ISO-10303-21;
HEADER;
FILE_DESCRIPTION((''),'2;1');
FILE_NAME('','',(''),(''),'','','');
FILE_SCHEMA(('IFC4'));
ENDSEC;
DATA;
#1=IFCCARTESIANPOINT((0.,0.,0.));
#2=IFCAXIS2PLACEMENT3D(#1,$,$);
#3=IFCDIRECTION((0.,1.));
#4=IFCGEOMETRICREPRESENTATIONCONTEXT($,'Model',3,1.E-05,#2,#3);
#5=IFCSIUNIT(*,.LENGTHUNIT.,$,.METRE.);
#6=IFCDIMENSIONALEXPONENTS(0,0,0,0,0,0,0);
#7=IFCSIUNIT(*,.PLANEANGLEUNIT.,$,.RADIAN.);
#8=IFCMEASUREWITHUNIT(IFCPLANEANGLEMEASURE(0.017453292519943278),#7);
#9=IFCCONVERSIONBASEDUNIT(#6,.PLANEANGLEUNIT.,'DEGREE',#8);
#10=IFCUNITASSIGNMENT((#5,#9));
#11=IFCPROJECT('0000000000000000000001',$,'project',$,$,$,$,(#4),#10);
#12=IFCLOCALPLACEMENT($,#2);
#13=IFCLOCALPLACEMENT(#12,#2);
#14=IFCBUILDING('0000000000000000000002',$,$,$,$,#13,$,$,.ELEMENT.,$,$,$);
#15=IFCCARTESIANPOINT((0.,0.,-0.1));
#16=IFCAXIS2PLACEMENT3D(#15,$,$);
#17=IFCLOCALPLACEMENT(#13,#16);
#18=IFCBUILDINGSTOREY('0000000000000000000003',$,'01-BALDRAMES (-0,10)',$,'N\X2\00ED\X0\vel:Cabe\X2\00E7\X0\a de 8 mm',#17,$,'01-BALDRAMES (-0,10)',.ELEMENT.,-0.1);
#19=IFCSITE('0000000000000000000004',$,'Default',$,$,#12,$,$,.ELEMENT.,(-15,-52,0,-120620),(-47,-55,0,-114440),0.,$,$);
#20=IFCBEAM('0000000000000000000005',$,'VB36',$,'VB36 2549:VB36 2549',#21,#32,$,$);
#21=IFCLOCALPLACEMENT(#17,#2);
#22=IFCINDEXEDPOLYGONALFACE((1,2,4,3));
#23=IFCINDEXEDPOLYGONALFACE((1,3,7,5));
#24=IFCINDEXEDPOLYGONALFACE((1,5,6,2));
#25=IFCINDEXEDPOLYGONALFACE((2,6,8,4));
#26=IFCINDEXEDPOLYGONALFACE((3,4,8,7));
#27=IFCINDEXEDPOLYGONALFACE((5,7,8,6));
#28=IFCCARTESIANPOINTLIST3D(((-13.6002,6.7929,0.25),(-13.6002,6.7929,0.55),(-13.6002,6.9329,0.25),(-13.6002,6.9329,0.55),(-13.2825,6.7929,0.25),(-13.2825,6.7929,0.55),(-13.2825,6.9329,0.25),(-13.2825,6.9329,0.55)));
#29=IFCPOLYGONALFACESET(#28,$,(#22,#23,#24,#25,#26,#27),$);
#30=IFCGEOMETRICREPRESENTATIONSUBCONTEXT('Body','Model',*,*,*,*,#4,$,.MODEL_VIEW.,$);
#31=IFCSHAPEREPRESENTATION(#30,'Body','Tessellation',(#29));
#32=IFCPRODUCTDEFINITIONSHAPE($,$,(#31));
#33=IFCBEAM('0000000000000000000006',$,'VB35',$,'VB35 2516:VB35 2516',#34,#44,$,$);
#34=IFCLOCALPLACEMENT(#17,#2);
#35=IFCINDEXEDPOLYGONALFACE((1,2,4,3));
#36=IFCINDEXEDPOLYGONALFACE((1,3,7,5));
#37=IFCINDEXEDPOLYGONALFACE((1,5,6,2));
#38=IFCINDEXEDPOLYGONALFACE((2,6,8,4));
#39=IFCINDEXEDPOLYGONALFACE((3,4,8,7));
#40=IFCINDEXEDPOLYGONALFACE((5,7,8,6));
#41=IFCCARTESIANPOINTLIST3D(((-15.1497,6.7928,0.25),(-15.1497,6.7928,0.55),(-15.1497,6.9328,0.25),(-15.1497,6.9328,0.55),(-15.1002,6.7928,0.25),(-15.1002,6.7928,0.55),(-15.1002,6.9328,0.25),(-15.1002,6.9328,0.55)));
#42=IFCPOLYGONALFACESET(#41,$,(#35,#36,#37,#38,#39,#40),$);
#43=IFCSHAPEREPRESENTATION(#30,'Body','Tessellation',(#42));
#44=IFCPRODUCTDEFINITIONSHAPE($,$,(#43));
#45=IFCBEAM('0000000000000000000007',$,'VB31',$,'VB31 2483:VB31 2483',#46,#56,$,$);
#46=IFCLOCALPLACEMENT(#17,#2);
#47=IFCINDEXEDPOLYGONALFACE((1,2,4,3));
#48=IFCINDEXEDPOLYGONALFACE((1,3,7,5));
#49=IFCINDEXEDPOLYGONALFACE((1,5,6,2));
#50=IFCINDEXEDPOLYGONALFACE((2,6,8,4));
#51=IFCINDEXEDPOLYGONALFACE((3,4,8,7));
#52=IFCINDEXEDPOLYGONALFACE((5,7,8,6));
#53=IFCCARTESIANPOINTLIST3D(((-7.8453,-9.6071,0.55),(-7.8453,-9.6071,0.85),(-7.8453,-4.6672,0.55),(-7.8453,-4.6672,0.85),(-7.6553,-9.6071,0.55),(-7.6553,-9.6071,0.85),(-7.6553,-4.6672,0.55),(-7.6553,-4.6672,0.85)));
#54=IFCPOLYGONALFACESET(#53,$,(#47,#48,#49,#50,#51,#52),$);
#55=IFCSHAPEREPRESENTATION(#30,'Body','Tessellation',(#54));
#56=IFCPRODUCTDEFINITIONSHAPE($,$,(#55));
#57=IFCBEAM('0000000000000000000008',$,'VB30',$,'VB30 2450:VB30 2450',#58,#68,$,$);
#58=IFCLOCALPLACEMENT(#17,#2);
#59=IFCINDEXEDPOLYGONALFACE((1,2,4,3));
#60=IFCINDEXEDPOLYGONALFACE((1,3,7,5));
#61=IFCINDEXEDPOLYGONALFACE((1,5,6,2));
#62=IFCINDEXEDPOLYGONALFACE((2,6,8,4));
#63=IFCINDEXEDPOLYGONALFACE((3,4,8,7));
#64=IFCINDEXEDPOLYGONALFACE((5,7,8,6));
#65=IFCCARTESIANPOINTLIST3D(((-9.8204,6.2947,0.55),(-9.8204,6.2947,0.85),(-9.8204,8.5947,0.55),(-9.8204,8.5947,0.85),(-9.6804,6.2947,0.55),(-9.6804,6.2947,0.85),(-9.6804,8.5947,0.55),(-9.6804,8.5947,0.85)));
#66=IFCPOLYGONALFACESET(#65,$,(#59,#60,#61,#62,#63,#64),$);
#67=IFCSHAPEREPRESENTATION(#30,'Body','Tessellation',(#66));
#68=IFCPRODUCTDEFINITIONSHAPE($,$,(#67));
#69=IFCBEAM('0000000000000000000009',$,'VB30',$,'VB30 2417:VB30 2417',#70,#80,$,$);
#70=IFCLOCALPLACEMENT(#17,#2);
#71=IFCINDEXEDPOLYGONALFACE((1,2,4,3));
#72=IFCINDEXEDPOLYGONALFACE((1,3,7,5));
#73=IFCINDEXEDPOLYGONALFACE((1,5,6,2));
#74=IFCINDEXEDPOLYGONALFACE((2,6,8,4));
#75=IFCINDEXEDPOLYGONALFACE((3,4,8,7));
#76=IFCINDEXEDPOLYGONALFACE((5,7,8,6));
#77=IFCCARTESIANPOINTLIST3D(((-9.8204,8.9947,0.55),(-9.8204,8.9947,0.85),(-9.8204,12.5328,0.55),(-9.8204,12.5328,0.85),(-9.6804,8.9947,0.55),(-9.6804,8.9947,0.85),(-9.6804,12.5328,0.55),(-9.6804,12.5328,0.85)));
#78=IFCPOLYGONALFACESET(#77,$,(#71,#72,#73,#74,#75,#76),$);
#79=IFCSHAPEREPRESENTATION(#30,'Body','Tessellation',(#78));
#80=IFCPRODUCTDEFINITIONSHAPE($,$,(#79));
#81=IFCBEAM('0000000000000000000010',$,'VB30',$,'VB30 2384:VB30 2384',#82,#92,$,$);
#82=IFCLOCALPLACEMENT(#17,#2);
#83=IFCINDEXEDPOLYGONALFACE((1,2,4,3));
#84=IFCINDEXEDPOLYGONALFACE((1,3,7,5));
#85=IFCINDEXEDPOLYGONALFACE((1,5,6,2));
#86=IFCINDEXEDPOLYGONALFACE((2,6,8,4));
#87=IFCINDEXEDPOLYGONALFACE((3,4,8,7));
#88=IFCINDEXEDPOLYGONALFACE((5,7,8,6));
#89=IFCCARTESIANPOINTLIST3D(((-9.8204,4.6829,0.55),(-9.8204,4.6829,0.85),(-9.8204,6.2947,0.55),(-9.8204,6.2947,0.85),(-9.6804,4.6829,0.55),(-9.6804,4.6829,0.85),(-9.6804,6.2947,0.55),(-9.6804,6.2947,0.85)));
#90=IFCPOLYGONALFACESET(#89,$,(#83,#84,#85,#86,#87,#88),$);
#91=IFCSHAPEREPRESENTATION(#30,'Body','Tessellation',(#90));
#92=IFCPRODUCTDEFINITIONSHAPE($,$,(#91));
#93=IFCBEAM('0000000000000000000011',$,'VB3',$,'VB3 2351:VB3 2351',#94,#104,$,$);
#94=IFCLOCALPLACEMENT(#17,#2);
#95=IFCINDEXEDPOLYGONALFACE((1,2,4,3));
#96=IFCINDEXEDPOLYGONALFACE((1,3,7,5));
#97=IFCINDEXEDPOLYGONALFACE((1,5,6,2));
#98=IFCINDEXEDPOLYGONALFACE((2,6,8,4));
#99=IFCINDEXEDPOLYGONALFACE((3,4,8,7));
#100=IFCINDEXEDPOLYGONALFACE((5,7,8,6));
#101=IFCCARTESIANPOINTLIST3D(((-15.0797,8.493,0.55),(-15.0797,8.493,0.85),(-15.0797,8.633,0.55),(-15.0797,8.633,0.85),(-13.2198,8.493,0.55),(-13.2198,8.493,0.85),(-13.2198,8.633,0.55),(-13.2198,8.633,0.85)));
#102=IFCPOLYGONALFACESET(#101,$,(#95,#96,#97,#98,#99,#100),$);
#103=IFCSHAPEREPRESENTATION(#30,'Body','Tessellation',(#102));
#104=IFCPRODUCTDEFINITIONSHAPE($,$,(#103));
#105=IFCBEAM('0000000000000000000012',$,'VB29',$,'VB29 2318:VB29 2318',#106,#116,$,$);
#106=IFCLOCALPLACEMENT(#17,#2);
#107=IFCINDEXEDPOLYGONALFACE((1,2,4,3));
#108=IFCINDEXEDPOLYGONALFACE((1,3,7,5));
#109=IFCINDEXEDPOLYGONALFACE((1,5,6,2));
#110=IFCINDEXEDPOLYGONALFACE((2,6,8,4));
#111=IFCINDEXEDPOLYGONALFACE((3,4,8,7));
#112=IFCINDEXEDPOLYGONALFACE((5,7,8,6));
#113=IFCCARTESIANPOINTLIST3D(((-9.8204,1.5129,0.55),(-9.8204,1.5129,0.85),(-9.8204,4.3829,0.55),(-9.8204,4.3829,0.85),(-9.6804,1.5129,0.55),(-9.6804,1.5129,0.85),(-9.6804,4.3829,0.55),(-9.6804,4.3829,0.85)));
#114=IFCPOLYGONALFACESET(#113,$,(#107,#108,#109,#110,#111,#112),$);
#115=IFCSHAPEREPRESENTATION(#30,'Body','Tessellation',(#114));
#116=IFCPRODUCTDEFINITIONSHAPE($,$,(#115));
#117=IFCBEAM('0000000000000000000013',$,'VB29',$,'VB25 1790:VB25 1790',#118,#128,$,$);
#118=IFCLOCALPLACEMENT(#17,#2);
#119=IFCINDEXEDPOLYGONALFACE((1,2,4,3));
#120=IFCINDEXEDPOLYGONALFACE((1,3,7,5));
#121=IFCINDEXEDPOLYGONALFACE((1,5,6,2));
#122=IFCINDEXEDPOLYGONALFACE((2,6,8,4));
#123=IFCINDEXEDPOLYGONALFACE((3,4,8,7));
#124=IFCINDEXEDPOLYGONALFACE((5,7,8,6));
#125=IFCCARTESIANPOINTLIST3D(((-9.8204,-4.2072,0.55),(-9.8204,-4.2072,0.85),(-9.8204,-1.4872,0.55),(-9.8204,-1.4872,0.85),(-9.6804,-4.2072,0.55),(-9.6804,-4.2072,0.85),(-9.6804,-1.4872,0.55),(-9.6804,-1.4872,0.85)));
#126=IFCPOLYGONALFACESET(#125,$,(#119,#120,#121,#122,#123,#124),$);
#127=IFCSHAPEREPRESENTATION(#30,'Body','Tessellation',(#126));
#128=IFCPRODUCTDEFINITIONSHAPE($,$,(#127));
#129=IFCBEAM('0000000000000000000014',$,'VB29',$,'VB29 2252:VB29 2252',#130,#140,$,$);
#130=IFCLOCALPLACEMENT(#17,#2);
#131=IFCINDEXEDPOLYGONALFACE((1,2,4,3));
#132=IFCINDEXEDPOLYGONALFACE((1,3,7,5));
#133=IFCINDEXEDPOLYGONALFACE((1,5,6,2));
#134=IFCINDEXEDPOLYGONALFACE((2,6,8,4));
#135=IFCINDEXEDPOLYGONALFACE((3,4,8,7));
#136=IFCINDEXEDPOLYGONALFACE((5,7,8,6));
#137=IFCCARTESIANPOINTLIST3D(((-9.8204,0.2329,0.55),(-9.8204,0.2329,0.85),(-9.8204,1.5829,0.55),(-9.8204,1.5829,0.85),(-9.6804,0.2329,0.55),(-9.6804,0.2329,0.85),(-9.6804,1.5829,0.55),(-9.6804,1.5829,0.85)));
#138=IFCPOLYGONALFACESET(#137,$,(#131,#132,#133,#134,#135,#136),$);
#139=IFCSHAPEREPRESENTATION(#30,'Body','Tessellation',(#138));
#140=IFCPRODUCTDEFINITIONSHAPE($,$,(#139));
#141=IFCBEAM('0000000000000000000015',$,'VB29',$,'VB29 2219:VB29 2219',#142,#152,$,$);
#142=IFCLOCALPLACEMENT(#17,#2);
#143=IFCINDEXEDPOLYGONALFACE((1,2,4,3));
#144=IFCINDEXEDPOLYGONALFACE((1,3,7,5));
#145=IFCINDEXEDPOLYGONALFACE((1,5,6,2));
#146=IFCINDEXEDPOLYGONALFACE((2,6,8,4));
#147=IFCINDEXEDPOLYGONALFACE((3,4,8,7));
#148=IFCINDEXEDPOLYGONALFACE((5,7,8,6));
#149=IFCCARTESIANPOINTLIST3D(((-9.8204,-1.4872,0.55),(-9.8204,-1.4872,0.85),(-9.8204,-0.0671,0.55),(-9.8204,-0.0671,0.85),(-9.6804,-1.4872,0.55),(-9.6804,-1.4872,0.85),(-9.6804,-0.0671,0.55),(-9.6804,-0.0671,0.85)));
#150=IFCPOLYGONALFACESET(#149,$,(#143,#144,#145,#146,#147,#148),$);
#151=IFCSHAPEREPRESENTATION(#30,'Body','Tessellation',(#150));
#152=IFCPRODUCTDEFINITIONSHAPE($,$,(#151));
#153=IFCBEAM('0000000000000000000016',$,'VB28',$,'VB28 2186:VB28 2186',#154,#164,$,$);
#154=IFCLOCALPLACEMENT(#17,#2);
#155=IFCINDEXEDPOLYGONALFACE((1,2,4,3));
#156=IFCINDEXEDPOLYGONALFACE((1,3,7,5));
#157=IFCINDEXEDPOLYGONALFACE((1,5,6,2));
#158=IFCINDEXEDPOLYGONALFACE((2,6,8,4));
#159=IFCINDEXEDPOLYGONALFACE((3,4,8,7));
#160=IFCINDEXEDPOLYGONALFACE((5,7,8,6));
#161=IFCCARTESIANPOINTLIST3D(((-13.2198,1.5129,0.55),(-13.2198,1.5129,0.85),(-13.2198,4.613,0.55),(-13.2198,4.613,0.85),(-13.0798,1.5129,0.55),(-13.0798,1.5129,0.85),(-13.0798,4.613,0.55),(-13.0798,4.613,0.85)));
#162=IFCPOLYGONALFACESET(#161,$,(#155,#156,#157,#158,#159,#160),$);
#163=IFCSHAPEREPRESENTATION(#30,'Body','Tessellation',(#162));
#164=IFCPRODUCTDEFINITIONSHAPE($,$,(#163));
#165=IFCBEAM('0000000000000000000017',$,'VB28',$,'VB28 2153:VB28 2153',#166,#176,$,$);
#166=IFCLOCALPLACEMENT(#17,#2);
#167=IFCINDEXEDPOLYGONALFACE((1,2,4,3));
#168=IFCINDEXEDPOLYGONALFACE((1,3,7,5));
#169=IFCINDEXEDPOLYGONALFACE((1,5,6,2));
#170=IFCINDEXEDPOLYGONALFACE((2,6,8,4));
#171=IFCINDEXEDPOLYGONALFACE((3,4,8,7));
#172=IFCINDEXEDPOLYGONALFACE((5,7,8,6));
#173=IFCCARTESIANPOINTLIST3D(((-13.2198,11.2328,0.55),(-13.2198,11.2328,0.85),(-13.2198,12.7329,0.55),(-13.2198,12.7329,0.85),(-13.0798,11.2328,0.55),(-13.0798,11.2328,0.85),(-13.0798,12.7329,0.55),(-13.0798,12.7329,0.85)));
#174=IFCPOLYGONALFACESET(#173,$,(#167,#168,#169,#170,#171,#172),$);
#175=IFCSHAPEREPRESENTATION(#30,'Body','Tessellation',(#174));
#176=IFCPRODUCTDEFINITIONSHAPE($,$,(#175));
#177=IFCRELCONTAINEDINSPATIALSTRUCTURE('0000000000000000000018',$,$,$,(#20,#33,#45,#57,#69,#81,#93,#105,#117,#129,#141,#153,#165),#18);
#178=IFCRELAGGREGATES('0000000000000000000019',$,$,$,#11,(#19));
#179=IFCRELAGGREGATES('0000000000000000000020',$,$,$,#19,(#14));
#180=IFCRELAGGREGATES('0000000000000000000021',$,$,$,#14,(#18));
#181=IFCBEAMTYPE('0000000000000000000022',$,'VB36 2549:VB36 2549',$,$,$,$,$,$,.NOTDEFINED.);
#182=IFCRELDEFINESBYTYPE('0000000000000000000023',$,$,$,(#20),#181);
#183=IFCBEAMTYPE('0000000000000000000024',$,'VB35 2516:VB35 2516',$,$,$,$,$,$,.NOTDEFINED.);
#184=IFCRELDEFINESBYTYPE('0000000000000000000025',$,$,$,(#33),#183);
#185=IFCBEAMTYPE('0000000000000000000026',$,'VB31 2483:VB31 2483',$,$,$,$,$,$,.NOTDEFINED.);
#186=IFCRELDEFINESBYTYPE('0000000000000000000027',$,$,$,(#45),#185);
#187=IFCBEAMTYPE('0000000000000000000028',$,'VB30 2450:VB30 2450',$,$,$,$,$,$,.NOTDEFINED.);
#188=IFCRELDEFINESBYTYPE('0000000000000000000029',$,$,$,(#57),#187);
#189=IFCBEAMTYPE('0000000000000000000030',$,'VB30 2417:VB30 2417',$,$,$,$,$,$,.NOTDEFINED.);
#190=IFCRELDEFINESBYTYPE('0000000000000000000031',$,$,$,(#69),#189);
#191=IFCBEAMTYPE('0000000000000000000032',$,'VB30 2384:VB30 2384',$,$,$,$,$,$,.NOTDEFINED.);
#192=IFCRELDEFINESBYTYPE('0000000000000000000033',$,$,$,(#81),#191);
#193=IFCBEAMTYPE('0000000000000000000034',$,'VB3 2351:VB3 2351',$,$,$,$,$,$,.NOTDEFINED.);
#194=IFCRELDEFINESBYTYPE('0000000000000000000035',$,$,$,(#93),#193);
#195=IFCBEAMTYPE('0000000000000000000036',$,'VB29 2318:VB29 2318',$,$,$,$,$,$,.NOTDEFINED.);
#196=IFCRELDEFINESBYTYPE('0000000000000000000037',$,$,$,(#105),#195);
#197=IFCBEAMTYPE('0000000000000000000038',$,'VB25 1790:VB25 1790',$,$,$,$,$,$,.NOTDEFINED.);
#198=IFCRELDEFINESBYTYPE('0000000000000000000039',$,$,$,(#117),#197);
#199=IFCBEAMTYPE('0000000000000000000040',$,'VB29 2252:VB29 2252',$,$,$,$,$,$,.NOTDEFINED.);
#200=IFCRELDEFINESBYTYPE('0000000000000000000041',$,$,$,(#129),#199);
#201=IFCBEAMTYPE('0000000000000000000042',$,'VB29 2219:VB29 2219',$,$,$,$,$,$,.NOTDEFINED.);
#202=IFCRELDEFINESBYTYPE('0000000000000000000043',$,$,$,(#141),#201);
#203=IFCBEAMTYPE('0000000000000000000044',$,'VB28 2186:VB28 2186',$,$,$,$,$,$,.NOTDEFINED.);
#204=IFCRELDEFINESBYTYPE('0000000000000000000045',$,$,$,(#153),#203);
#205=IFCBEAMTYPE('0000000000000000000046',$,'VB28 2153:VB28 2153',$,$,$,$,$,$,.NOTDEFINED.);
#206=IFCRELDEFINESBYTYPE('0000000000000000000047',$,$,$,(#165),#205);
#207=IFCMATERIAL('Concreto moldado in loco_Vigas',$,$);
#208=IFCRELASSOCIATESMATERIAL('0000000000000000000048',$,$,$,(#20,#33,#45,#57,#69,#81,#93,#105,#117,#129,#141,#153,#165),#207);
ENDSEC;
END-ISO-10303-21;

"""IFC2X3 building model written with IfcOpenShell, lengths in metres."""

from ifc_helpers import new_model, entity, si_unit, converted_unit, direction, frame, frame_2d, origin, place, context, subcontext, project, spatial, rectangle, extrude, material, type_object, element, save


model = new_model("IFC2X3")

# Units and contexts
model_context = context("Model", 3, precision=1e-05, world=origin(), true_north=direction((0.0, 1.0)))
body_context = subcontext(model_context, "Body", "Model", "MODEL_VIEW")
ifc_project = project(units=[si_unit("LENGTHUNIT", "METRE"), converted_unit("PLANEANGLEUNIT", "DEGREE", entity("IfcPlaneAngleMeasure", 0.017453292519943278), si_unit("PLANEANGLEUNIT", "RADIAN"), dimensions=[0, 0, 0, 0, 0, 0, 0])], contexts=[model_context])

# Site, building, storey
site_placement = place(None, origin())
site = spatial("IfcSite", under=ifc_project, at=site_placement, Name="Default", CompositionType="ELEMENT", RefLatitude=(-15, -52, 0, -120620), RefLongitude=(-47, -55, 0, -114440), RefElevation=0.0)
building_placement = place(site_placement, origin())
building = spatial("IfcBuilding", under=site, at=building_placement, CompositionType="ELEMENT")
storey_placement = place(building_placement, frame((0.0, 0.0, -0.1)))
storey = spatial("IfcBuildingStorey", under=building, at=storey_placement, Name="01-BALDRAMES (-0,10)", ObjectType="Nível:Cabeça de 8 mm", LongName="01-BALDRAMES (-0,10)", CompositionType="ELEMENT", Elevation=-0.1)

# Beams
ifc_material = material(Name="Concreto moldado in loco_Vigas")
beam_type_1 = type_object("IfcBeamType", Name="VB36 2549:VB36 2549", PredefinedType="NOTDEFINED")
beam_1_placement = place(storey_placement, origin())
element("IfcBeam", 1, at=beam_1_placement, inside=storey, type_object=beam_type_1, material=ifc_material, Name="VB36", ObjectType="VB36 2549:VB36 2549", context=body_context, shape_type="SweptSolid", body=[
    extrude(rectangle(XDim=0.3, YDim=0.14, at=frame_2d((0.0, 0.0), x_axis=(1.0, 0.0))), frame((-13.6002, 6.8629, 0.4), z_axis=(1.0, 0.0, 0.0), x_axis=(0.0, 0.0, -1.0)), (0.0, 0.0, 1.0), 0.3178),
])
beam_type_2 = type_object("IfcBeamType", Name="VB35 2516:VB35 2516", PredefinedType="NOTDEFINED")
beam_2_placement = place(storey_placement, origin())
element("IfcBeam", 2, at=beam_2_placement, inside=storey, type_object=beam_type_2, material=ifc_material, Name="VB35", ObjectType="VB35 2516:VB35 2516", context=body_context, shape_type="SweptSolid", body=[
    extrude(rectangle(XDim=0.3, YDim=0.14, at=frame_2d((0.0, 0.0), x_axis=(1.0, 0.0))), frame((-15.1497, 6.8628, 0.4), z_axis=(1.0, 0.0, 0.0), x_axis=(0.0, 0.0, -1.0)), (0.0, 0.0, 1.0), 0.0495),
])
beam_type_3 = type_object("IfcBeamType", Name="VB31 2483:VB31 2483", PredefinedType="NOTDEFINED")
beam_3_placement = place(storey_placement, origin())
element("IfcBeam", 3, at=beam_3_placement, inside=storey, type_object=beam_type_3, material=ifc_material, Name="VB31", ObjectType="VB31 2483:VB31 2483", context=body_context, shape_type="SweptSolid", body=[
    extrude(rectangle(XDim=0.3, YDim=4.9399, at=frame_2d((0.0, 0.0), x_axis=(0.0, 1.0))), frame((-7.8453, -7.1371, 0.7), z_axis=(1.0, 0.0, 0.0), x_axis=(0.0, -1.0, 0.0)), (0.0, 0.0, 1.0), 0.19),
])
beam_type_4 = type_object("IfcBeamType", Name="VB30 2450:VB30 2450", PredefinedType="NOTDEFINED")
beam_4_placement = place(storey_placement, origin())
element("IfcBeam", 4, at=beam_4_placement, inside=storey, type_object=beam_type_4, material=ifc_material, Name="VB30", ObjectType="VB30 2450:VB30 2450", context=body_context, shape_type="SweptSolid", body=[
    extrude(rectangle(XDim=0.3, YDim=2.3, at=frame_2d((0.0, 0.0), x_axis=(0.0, 1.0))), frame((-9.8204, 7.4447, 0.7), z_axis=(1.0, 0.0, 0.0), x_axis=(0.0, -1.0, 0.0)), (0.0, 0.0, 1.0), 0.14),
])
beam_type_5 = type_object("IfcBeamType", Name="VB30 2417:VB30 2417", PredefinedType="NOTDEFINED")
beam_5_placement = place(storey_placement, origin())
element("IfcBeam", 5, at=beam_5_placement, inside=storey, type_object=beam_type_5, material=ifc_material, Name="VB30", ObjectType="VB30 2417:VB30 2417", context=body_context, shape_type="SweptSolid", body=[
    extrude(rectangle(XDim=0.3, YDim=3.5381, at=frame_2d((0.0, 0.0), x_axis=(0.0, 1.0))), frame((-9.8204, 10.7638, 0.7), z_axis=(1.0, 0.0, 0.0), x_axis=(0.0, -1.0, 0.0)), (0.0, 0.0, 1.0), 0.14),
])
beam_type_6 = type_object("IfcBeamType", Name="VB30 2384:VB30 2384", PredefinedType="NOTDEFINED")
beam_6_placement = place(storey_placement, origin())
element("IfcBeam", 6, at=beam_6_placement, inside=storey, type_object=beam_type_6, material=ifc_material, Name="VB30", ObjectType="VB30 2384:VB30 2384", context=body_context, shape_type="SweptSolid", body=[
    extrude(rectangle(XDim=0.3, YDim=1.6118, at=frame_2d((0.0, 0.0), x_axis=(0.0, 1.0))), frame((-9.8204, 5.4888, 0.7), z_axis=(1.0, 0.0, 0.0), x_axis=(0.0, -1.0, 0.0)), (0.0, 0.0, 1.0), 0.14),
])
beam_type_7 = type_object("IfcBeamType", Name="VB3 2351:VB3 2351", PredefinedType="NOTDEFINED")
beam_7_placement = place(storey_placement, origin())
element("IfcBeam", 7, at=beam_7_placement, inside=storey, type_object=beam_type_7, material=ifc_material, Name="VB3", ObjectType="VB3 2351:VB3 2351", context=body_context, shape_type="SweptSolid", body=[
    extrude(rectangle(XDim=0.3, YDim=0.14, at=frame_2d((0.0, 0.0), x_axis=(1.0, 0.0))), frame((-15.0797, 8.563, 0.7), z_axis=(1.0, 0.0, 0.0), x_axis=(0.0, 0.0, -1.0)), (0.0, 0.0, 1.0), 1.8599),
])
beam_type_8 = type_object("IfcBeamType", Name="VB29 2318:VB29 2318", PredefinedType="NOTDEFINED")
beam_8_placement = place(storey_placement, origin())
element("IfcBeam", 8, at=beam_8_placement, inside=storey, type_object=beam_type_8, material=ifc_material, Name="VB29", ObjectType="VB29 2318:VB29 2318", context=body_context, shape_type="SweptSolid", body=[
    extrude(rectangle(XDim=0.3, YDim=2.87, at=frame_2d((0.0, 0.0), x_axis=(0.0, 1.0))), frame((-9.8204, 2.9479, 0.7), z_axis=(1.0, 0.0, 0.0), x_axis=(0.0, -1.0, 0.0)), (0.0, 0.0, 1.0), 0.14),
])
beam_type_9 = type_object("IfcBeamType", Name="VB25 1790:VB25 1790", PredefinedType="NOTDEFINED")
beam_9_placement = place(storey_placement, origin())
element("IfcBeam", 9, at=beam_9_placement, inside=storey, type_object=beam_type_9, material=ifc_material, Name="VB29", ObjectType="VB25 1790:VB25 1790", context=body_context, shape_type="SweptSolid", body=[
    extrude(rectangle(XDim=0.3, YDim=2.72, at=frame_2d((0.0, 0.0), x_axis=(0.0, 1.0))), frame((-9.8204, -2.8472, 0.7), z_axis=(1.0, 0.0, 0.0), x_axis=(0.0, -1.0, 0.0)), (0.0, 0.0, 1.0), 0.14),
])
beam_type_10 = type_object("IfcBeamType", Name="VB29 2252:VB29 2252", PredefinedType="NOTDEFINED")
beam_10_placement = place(storey_placement, origin())
element("IfcBeam", 10, at=beam_10_placement, inside=storey, type_object=beam_type_10, material=ifc_material, Name="VB29", ObjectType="VB29 2252:VB29 2252", context=body_context, shape_type="SweptSolid", body=[
    extrude(rectangle(XDim=0.3, YDim=1.35, at=frame_2d((0.0, 0.0), x_axis=(0.0, 1.0))), frame((-9.8204, 0.9079, 0.7), z_axis=(1.0, 0.0, 0.0), x_axis=(0.0, -1.0, 0.0)), (0.0, 0.0, 1.0), 0.14),
])
beam_type_11 = type_object("IfcBeamType", Name="VB29 2219:VB29 2219", PredefinedType="NOTDEFINED")
beam_11_placement = place(storey_placement, origin())
element("IfcBeam", 11, at=beam_11_placement, inside=storey, type_object=beam_type_11, material=ifc_material, Name="VB29", ObjectType="VB29 2219:VB29 2219", context=body_context, shape_type="SweptSolid", body=[
    extrude(rectangle(XDim=0.3, YDim=1.4201, at=frame_2d((0.0, 0.0), x_axis=(0.0, 1.0))), frame((-9.8204, -0.7771, 0.7), z_axis=(1.0, 0.0, 0.0), x_axis=(0.0, -1.0, 0.0)), (0.0, 0.0, 1.0), 0.14),
])
beam_type_12 = type_object("IfcBeamType", Name="VB28 2186:VB28 2186", PredefinedType="NOTDEFINED")
beam_12_placement = place(storey_placement, origin())
element("IfcBeam", 12, at=beam_12_placement, inside=storey, type_object=beam_type_12, material=ifc_material, Name="VB28", ObjectType="VB28 2186:VB28 2186", context=body_context, shape_type="SweptSolid", body=[
    extrude(rectangle(XDim=0.3, YDim=3.1001, at=frame_2d((0.0, 0.0), x_axis=(0.0, 1.0))), frame((-13.2198, 3.063, 0.7), z_axis=(1.0, 0.0, 0.0), x_axis=(0.0, -1.0, 0.0)), (0.0, 0.0, 1.0), 0.14),
])
beam_type_13 = type_object("IfcBeamType", Name="VB28 2153:VB28 2153", PredefinedType="NOTDEFINED")
beam_13_placement = place(storey_placement, origin())
element("IfcBeam", 13, at=beam_13_placement, inside=storey, type_object=beam_type_13, material=ifc_material, Name="VB28", ObjectType="VB28 2153:VB28 2153", context=body_context, shape_type="SweptSolid", body=[
    extrude(rectangle(XDim=0.3, YDim=1.5001, at=frame_2d((0.0, 0.0), x_axis=(0.0, 1.0))), frame((-13.2198, 11.9829, 0.7), z_axis=(1.0, 0.0, 0.0), x_axis=(0.0, -1.0, 0.0)), (0.0, 0.0, 1.0), 0.14),
])

save(model, "model.ifc")
